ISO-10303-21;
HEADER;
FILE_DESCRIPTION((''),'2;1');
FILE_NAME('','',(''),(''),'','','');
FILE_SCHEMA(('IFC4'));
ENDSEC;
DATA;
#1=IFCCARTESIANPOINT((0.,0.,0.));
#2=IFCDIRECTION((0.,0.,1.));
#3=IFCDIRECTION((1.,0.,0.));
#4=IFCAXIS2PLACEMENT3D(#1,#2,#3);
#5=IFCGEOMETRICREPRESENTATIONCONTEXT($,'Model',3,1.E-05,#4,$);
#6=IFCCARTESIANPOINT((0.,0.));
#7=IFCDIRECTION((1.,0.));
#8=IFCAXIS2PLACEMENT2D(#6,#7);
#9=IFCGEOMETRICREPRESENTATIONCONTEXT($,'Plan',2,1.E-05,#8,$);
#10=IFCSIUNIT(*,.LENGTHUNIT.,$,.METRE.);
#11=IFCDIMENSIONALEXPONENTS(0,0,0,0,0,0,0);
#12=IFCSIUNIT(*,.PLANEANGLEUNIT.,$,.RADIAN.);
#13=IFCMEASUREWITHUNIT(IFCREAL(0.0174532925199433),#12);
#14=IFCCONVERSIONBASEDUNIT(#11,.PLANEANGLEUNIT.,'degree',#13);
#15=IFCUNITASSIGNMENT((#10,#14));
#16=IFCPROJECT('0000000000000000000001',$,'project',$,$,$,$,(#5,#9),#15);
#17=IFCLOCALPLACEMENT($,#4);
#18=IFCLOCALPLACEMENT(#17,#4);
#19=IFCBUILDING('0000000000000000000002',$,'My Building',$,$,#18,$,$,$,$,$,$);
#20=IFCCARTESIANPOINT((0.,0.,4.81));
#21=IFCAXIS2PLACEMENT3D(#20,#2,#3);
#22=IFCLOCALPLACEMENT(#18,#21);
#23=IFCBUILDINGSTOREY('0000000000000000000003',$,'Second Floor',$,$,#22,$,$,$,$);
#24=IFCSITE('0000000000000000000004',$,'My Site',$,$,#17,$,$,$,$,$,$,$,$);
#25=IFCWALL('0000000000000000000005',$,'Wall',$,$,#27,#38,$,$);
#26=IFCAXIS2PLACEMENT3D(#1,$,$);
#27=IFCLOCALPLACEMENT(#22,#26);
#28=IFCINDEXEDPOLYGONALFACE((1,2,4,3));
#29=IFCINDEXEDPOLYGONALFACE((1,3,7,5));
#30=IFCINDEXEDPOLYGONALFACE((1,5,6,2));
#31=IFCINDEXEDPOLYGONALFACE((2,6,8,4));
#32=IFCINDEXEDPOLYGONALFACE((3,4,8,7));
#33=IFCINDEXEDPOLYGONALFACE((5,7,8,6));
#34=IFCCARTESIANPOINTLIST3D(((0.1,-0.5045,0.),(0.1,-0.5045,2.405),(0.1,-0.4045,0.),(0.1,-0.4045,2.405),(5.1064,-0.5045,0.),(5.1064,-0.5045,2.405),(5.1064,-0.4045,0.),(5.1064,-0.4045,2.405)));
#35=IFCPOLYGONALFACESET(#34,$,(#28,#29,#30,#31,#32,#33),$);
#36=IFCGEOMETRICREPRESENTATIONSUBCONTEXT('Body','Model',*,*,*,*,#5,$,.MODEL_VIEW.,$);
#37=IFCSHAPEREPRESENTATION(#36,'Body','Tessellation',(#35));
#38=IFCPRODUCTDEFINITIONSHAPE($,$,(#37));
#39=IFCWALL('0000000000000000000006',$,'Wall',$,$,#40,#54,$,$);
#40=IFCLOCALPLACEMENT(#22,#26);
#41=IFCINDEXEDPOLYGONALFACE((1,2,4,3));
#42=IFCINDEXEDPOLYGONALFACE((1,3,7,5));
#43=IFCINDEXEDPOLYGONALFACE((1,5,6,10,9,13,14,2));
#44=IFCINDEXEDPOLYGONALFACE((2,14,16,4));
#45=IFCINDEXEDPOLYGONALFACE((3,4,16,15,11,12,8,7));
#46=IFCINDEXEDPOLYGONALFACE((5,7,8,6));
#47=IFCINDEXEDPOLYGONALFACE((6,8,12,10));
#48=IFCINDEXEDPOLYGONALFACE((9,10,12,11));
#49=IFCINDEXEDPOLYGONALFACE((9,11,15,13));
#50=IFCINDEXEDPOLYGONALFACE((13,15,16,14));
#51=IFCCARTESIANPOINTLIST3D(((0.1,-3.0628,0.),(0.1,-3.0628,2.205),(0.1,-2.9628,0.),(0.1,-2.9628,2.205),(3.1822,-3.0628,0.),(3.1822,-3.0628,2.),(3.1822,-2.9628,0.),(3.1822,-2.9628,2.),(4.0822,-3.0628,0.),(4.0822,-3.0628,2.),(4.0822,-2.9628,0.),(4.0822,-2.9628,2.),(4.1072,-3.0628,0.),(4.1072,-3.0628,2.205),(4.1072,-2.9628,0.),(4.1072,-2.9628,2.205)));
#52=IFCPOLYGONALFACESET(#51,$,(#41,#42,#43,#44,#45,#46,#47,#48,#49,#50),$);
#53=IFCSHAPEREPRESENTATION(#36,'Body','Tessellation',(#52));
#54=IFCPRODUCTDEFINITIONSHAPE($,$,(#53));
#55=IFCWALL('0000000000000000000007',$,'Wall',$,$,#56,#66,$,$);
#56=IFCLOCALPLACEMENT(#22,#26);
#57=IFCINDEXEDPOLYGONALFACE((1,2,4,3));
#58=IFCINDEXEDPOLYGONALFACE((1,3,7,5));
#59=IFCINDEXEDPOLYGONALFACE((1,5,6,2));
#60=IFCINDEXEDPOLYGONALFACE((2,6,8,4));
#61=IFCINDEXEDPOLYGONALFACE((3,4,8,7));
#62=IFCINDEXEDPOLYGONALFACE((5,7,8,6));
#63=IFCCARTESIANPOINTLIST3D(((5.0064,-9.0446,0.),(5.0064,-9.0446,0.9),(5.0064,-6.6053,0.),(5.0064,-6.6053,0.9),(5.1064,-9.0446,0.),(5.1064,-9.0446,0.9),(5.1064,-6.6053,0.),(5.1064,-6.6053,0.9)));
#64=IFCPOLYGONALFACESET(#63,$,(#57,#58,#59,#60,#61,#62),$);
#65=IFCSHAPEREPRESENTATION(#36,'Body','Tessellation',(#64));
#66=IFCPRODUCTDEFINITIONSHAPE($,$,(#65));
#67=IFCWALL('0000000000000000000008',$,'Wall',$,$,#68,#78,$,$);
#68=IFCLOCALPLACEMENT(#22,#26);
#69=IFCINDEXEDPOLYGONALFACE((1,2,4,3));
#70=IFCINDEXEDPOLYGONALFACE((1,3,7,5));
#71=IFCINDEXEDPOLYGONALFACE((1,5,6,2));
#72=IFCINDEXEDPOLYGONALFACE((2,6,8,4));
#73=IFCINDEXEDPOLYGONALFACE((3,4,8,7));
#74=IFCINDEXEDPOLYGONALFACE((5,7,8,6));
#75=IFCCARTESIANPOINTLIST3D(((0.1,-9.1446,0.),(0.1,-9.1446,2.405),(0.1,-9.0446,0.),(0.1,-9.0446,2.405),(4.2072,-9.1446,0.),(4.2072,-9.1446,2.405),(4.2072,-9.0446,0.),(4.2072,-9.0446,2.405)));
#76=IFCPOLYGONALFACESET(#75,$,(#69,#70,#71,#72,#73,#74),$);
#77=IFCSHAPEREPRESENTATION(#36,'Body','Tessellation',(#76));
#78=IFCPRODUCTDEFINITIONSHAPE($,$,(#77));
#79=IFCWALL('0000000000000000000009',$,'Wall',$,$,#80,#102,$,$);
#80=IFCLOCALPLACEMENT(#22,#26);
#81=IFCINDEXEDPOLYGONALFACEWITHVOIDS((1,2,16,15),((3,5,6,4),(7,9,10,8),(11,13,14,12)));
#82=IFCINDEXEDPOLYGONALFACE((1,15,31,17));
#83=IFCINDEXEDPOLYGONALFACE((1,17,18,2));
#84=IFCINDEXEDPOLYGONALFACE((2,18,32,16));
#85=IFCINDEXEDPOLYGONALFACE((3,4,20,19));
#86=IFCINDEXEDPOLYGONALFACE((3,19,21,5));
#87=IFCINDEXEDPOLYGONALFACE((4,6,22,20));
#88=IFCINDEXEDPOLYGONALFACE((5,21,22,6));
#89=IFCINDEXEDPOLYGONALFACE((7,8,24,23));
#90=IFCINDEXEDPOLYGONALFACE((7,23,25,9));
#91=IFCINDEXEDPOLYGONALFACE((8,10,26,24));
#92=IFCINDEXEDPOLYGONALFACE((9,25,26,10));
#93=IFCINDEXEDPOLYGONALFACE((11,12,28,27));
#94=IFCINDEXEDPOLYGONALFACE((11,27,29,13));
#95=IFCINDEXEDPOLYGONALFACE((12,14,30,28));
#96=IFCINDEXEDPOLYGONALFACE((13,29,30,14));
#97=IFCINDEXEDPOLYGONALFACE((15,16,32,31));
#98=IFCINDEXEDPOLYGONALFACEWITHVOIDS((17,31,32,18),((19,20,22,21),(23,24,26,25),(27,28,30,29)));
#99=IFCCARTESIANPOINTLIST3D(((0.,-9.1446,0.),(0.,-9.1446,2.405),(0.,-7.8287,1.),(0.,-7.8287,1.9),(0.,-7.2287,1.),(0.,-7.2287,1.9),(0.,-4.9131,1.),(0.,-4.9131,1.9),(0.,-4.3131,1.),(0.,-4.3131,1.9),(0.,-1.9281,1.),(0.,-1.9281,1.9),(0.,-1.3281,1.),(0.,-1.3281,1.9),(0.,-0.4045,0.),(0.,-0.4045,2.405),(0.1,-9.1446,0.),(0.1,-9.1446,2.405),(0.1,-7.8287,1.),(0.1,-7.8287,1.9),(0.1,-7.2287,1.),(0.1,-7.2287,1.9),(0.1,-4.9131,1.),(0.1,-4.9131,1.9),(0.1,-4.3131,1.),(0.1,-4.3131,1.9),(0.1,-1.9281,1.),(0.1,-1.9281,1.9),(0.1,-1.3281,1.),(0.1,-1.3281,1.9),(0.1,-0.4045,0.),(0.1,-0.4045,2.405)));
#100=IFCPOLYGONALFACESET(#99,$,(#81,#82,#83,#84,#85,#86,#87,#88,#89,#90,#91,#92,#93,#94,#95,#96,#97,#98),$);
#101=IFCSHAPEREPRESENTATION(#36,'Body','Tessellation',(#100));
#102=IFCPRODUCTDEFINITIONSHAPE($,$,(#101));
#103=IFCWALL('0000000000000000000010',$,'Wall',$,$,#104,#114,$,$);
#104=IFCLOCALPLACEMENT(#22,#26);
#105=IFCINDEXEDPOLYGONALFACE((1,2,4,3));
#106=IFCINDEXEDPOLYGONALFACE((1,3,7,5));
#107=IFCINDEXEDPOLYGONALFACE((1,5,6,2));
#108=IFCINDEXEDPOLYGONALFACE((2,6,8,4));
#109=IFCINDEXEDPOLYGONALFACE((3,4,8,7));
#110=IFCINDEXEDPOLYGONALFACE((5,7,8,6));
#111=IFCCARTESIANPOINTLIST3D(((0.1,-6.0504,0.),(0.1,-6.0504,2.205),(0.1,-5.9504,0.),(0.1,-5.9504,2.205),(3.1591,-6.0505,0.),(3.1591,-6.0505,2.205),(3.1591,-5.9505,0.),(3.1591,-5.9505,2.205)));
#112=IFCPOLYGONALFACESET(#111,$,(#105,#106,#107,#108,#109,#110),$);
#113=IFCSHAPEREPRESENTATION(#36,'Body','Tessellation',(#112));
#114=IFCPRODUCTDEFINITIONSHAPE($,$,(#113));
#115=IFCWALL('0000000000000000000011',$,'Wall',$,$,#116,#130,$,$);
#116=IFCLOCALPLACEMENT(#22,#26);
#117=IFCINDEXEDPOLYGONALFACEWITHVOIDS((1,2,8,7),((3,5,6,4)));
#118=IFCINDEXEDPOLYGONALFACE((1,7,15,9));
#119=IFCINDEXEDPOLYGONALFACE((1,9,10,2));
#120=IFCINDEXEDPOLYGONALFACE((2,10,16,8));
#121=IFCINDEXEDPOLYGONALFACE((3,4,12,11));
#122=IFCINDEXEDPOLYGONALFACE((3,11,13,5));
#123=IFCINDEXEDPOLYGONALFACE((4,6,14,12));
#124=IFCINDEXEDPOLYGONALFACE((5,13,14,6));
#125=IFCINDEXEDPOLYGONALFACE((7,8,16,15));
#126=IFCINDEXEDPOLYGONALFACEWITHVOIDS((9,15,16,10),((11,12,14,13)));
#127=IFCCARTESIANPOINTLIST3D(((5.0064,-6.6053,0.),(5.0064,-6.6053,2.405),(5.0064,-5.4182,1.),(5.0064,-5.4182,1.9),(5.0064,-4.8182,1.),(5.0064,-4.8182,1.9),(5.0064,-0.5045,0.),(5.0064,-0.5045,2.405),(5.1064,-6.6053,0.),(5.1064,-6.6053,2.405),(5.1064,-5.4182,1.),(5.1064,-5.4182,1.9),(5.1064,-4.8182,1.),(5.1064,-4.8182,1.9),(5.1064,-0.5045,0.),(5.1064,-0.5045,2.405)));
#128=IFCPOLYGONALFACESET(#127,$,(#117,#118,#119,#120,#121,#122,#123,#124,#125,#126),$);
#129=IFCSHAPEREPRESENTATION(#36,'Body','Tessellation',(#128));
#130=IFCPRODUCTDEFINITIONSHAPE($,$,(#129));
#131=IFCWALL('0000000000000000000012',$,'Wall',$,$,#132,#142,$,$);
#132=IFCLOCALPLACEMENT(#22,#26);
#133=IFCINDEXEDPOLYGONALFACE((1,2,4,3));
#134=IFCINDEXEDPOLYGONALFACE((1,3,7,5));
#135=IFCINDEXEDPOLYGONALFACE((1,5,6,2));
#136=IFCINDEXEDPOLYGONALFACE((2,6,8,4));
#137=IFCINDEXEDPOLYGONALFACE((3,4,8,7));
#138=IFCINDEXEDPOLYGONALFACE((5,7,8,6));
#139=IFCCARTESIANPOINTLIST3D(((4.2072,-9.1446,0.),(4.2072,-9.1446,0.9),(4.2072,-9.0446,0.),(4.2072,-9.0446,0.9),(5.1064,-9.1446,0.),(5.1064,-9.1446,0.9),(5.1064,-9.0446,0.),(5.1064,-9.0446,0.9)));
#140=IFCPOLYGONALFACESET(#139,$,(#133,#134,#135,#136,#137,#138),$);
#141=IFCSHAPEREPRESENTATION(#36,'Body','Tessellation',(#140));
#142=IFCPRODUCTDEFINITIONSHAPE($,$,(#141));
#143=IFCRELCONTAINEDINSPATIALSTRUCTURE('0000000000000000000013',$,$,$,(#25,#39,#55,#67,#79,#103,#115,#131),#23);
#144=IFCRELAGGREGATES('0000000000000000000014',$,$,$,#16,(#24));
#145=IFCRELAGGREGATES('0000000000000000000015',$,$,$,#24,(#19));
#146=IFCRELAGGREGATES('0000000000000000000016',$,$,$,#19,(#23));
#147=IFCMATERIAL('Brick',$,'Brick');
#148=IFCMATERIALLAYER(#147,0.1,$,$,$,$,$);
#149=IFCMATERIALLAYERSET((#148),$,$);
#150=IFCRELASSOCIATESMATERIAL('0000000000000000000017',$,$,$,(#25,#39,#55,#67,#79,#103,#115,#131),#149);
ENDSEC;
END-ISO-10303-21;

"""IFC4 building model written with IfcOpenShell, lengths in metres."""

from ifc_helpers import new_model, entity, si_unit, converted_unit, frame, origin_with_axes, origin_2d_with_axis, place, context, subcontext, project, spatial, line, indexed_curve, outline, extrude, source, transform, mapped, material, layer, layer_set, layer_usage, element, save


model = new_model("IFC4")

# Units and contexts
model_context = context("Model", 3, precision=1e-05, world=origin_with_axes())
plan_context = context("Plan", 2, precision=1e-05, world=origin_2d_with_axis())
body_context = subcontext(model_context, "Body", "Model", "MODEL_VIEW")
ifc_project = project(units=[si_unit("LENGTHUNIT", "METRE"), converted_unit("PLANEANGLEUNIT", "degree", entity("IfcReal", 0.0174532925199433), si_unit("PLANEANGLEUNIT", "RADIAN"), dimensions=[0, 0, 0, 0, 0, 0, 0])], contexts=[model_context, plan_context])

# Site, building, storey
site_placement = place(None, origin_with_axes())
site = spatial("IfcSite", under=ifc_project, at=site_placement, Name="My Site")
building_placement = place(site_placement, origin_with_axes())
building = spatial("IfcBuilding", under=site, at=building_placement, Name="My Building")
storey_placement = place(building_placement, frame((0.0, 0.0, 4.81), z_axis=(0.0, 0.0, 1.0), x_axis=(1.0, 0.0, 0.0)))
storey = spatial("IfcBuildingStorey", under=building, at=storey_placement, Name="Second Floor")

# Shared definitions
ifc_material_1 = material(Name="Brick", Category="Brick")
ifc_layer_1 = layer(ifc_material_1, 0.1)
ifc_layer_set_1 = layer_set([ifc_layer_1])

# Shared definitions
shared_shape_1 = source(origin_with_axes(), body_context, "Body", "SweptSolid", [
    extrude(outline(indexed_curve([(0.0, 0.0), (0.9, 0.0), (0.9, 2.0), (0.0, 2.0)], segments=[line(1, 2, 3, 4, 1)])), frame((0.0, -0.1, 0.0), z_axis=(0.0, -1.0, 0.0), x_axis=(1.0, 0.0, 0.0)), (0.0, 0.0, -1.0), 0.3),
])

# Wall
ifc_layer_usage_1 = layer_usage(ifc_layer_set_1, "AXIS2", "POSITIVE", 0.0)
wall_1_placement = place(storey_placement, frame((5.1064, -0.4045, 0.0), z_axis=(0.0, 0.0, 1.0), x_axis=(-1.0, 0.0, 0.0)))
element("IfcWall", 1, at=wall_1_placement, inside=storey, material=ifc_layer_usage_1, Name="Wall", context=body_context, shape_type="SweptSolid", body=[
    extrude(outline(indexed_curve([(0.0, 0.0), (0.0, 0.1), (5.0064, 0.1), (5.0064, 0.0), (0.0, 0.0)], self_intersect=False)), origin_with_axes(), (0.0, 0.0, 1.0), 2.405),
])

# Wall, opening
ifc_layer_usage_2 = layer_usage(ifc_layer_set_1, "AXIS2", "POSITIVE", 0.0)
wall_2_placement = place(storey_placement, frame((4.1072, -2.9628, 0.0), z_axis=(0.0, 0.0, 1.0), x_axis=(-1.0, 0.0, 0.0)))
wall_2 = element("IfcWall", 2, at=wall_2_placement, inside=storey, material=ifc_layer_usage_2, Name="Wall", context=body_context, shape_type="SweptSolid", body=[
    extrude(outline(indexed_curve([(0.0, 0.0), (0.0, 0.1), (4.0072, 0.1), (4.0072, 0.0), (0.0, 0.0)], self_intersect=False)), origin_with_axes(), (0.0, 0.0, 1.0), 2.205),
])
opening_1_placement = place(wall_2_placement, frame((0.025, 0.0, 0.0), z_axis=(0.0, 0.0, 1.0), x_axis=(1.0, 0.0, 0.0)))
element("IfcOpeningElement", 3, at=opening_1_placement, cuts=wall_2, PredefinedType="OPENING", context=body_context, shape_type="MappedRepresentation", body=[
    mapped(shared_shape_1, transform((0.0, 0.0, 0.0), x_axis=(1.0, 0.0, 0.0), y_axis=(0.0, 1.0, 0.0), z_axis=(0.0, 0.0, 1.0), scale=1.0)),
])

# Walls
ifc_layer_usage_3 = layer_usage(ifc_layer_set_1, "AXIS2", "POSITIVE", 0.0)
wall_3_placement = place(storey_placement, frame((5.1064, -9.0446, 0.0), z_axis=(0.0, 0.0, 1.0), x_axis=(0.000001, 1.0, 0.0)))
element("IfcWall", 4, at=wall_3_placement, inside=storey, material=ifc_layer_usage_3, Name="Wall", context=body_context, shape_type="SweptSolid", body=[
    extrude(outline(indexed_curve([(0.0, 0.0), (0.0, 0.1), (2.4394, 0.1), (2.4394, 0.0), (0.0, 0.0)], self_intersect=False)), origin_with_axes(), (0.0, 0.0, 1.0), 0.9),
])
ifc_layer_usage_4 = layer_usage(ifc_layer_set_1, "AXIS2", "POSITIVE", 0.0)
wall_4_placement = place(storey_placement, frame((0.1, -9.1446, 0.0), z_axis=(0.0, 0.0, 1.0), x_axis=(1.0, 0.0, 0.0)))
element("IfcWall", 5, at=wall_4_placement, inside=storey, material=ifc_layer_usage_4, Name="Wall", context=body_context, shape_type="SweptSolid", body=[
    extrude(outline(indexed_curve([(0.0, 0.0), (0.0, 0.1), (4.1072, 0.1), (4.1072, 0.0), (0.0, 0.0)], self_intersect=False)), origin_with_axes(), (0.0, 0.0, 1.0), 2.405),
])

# Wall, openings
ifc_layer_usage_5 = layer_usage(ifc_layer_set_1, "AXIS2", "POSITIVE", 0.0)
wall_5_placement = place(storey_placement, frame((0.0, -0.4045, 0.0), z_axis=(0.0, 0.0, 1.0), x_axis=(-0.000001, -1.0, 0.0)))
wall_5 = element("IfcWall", 6, at=wall_5_placement, inside=storey, material=ifc_layer_usage_5, Name="Wall", context=body_context, shape_type="SweptSolid", body=[
    extrude(outline(indexed_curve([(0.0, 0.0), (0.0, 0.1), (8.7401, 0.1), (8.7401, 0.0), (0.0, 0.0)], self_intersect=False)), origin_with_axes(), (0.0, 0.0, 1.0), 2.405),
])
shared_shape_2 = source(origin_with_axes(), body_context, "Body", "SweptSolid", [
    extrude(outline(indexed_curve([(0.0, 0.0), (0.6, 0.0), (0.6, 0.9), (0.0, 0.9)], segments=[line(1, 2, 3, 4, 1)])), frame((0.0, -0.1, 0.0), z_axis=(0.0, -1.0, 0.0), x_axis=(1.0, 0.0, 0.0)), (0.0, 0.0, -1.0), 0.3),
])
opening_2_placement = place(wall_5_placement, frame((6.8242, 0.0, 1.0), z_axis=(0.0, 0.0, 1.0), x_axis=(1.0, 0.0, 0.0)))
element("IfcOpeningElement", 7, at=opening_2_placement, cuts=wall_5, PredefinedType="OPENING", context=body_context, shape_type="MappedRepresentation", body=[
    mapped(shared_shape_2, transform((0.0, 0.0, 0.0), x_axis=(1.0, 0.0, 0.0), y_axis=(0.0, 1.0, 0.0), z_axis=(0.0, 0.0, 1.0), scale=1.0)),
])
opening_3_placement = place(wall_5_placement, frame((4.5086, 0.15, 1.0), z_axis=(0.0, 0.0, 1.0), x_axis=(-1.0, 0.0, 0.0)))
element("IfcOpeningElement", 8, at=opening_3_placement, cuts=wall_5, PredefinedType="OPENING", context=body_context, shape_type="MappedRepresentation", body=[
    mapped(shared_shape_2, transform((0.0, 0.0, 0.0), x_axis=(1.0, 0.0, 0.0), y_axis=(0.0, 1.0, 0.0), z_axis=(0.0, 0.0, 1.0), scale=1.0)),
])
opening_4_placement = place(wall_5_placement, frame((1.5236, 0.125, 1.0), z_axis=(0.0, 0.0, 1.0), x_axis=(-1.0, 0.0, 0.0)))
element("IfcOpeningElement", 9, at=opening_4_placement, cuts=wall_5, PredefinedType="OPENING", context=body_context, shape_type="MappedRepresentation", body=[
    mapped(shared_shape_2, transform((0.0, 0.0, 0.0), x_axis=(1.0, 0.0, 0.0), y_axis=(0.0, 1.0, 0.0), z_axis=(0.0, 0.0, 1.0), scale=1.0)),
])

# Wall
ifc_layer_usage_6 = layer_usage(ifc_layer_set_1, "AXIS2", "POSITIVE", 0.0)
wall_6_placement = place(storey_placement, frame((3.1591, -5.9505, 0.0), z_axis=(0.0, 0.0, 1.0), x_axis=(-1.0, 0.0, 0.0)))
element("IfcWall", 10, at=wall_6_placement, inside=storey, material=ifc_layer_usage_6, Name="Wall", context=body_context, shape_type="SweptSolid", body=[
    extrude(outline(indexed_curve([(0.0, 0.0), (0.0, 0.1), (3.0591, 0.1), (3.0591, 0.0), (0.0, 0.0)], self_intersect=False)), origin_with_axes(), (0.0, 0.0, 1.0), 2.205),
])

# Wall, opening
ifc_layer_usage_7 = layer_usage(ifc_layer_set_1, "AXIS2", "POSITIVE", 0.0)
wall_7_placement = place(storey_placement, frame((5.1064, -6.6053, 0.0), z_axis=(0.0, 0.0, 1.0), x_axis=(0.000001, 1.0, 0.0)))
wall_7 = element("IfcWall", 11, at=wall_7_placement, inside=storey, material=ifc_layer_usage_7, Name="Wall", context=body_context, shape_type="SweptSolid", body=[
    extrude(outline(indexed_curve([(0.0, 0.0), (0.0, 0.1), (6.1008, 0.1), (6.1008, 0.0), (0.0, 0.0)], self_intersect=False)), origin_with_axes(), (0.0, 0.0, 1.0), 2.405),
])
opening_5_placement = place(wall_7_placement, frame((1.1871, 0.0, 1.0), z_axis=(0.0, 0.0, 1.0), x_axis=(1.0, 0.0, 0.0)))
element("IfcOpeningElement", 12, at=opening_5_placement, cuts=wall_7, PredefinedType="OPENING", context=body_context, shape_type="MappedRepresentation", body=[
    mapped(shared_shape_2, transform((0.0, 0.0, 0.0), x_axis=(1.0, 0.0, 0.0), y_axis=(0.0, 1.0, 0.0), z_axis=(0.0, 0.0, 1.0), scale=1.0)),
])

# Wall
ifc_layer_usage_8 = layer_usage(ifc_layer_set_1, "AXIS2", "POSITIVE", 0.0)
wall_8_placement = place(storey_placement, frame((4.2072, -9.1446, 0.0), z_axis=(0.0, 0.0, 1.0), x_axis=(1.0, 0.0, 0.0)))
element("IfcWall", 13, at=wall_8_placement, inside=storey, material=ifc_layer_usage_8, Name="Wall", context=body_context, shape_type="SweptSolid", body=[
    extrude(outline(indexed_curve([(0.0, 0.0), (0.0, 0.1), (0.8992, 0.1), (0.8992, 0.0), (0.0, 0.0)], self_intersect=False)), origin_with_axes(), (0.0, 0.0, 1.0), 0.9),
])

save(model, "model.ifc")
